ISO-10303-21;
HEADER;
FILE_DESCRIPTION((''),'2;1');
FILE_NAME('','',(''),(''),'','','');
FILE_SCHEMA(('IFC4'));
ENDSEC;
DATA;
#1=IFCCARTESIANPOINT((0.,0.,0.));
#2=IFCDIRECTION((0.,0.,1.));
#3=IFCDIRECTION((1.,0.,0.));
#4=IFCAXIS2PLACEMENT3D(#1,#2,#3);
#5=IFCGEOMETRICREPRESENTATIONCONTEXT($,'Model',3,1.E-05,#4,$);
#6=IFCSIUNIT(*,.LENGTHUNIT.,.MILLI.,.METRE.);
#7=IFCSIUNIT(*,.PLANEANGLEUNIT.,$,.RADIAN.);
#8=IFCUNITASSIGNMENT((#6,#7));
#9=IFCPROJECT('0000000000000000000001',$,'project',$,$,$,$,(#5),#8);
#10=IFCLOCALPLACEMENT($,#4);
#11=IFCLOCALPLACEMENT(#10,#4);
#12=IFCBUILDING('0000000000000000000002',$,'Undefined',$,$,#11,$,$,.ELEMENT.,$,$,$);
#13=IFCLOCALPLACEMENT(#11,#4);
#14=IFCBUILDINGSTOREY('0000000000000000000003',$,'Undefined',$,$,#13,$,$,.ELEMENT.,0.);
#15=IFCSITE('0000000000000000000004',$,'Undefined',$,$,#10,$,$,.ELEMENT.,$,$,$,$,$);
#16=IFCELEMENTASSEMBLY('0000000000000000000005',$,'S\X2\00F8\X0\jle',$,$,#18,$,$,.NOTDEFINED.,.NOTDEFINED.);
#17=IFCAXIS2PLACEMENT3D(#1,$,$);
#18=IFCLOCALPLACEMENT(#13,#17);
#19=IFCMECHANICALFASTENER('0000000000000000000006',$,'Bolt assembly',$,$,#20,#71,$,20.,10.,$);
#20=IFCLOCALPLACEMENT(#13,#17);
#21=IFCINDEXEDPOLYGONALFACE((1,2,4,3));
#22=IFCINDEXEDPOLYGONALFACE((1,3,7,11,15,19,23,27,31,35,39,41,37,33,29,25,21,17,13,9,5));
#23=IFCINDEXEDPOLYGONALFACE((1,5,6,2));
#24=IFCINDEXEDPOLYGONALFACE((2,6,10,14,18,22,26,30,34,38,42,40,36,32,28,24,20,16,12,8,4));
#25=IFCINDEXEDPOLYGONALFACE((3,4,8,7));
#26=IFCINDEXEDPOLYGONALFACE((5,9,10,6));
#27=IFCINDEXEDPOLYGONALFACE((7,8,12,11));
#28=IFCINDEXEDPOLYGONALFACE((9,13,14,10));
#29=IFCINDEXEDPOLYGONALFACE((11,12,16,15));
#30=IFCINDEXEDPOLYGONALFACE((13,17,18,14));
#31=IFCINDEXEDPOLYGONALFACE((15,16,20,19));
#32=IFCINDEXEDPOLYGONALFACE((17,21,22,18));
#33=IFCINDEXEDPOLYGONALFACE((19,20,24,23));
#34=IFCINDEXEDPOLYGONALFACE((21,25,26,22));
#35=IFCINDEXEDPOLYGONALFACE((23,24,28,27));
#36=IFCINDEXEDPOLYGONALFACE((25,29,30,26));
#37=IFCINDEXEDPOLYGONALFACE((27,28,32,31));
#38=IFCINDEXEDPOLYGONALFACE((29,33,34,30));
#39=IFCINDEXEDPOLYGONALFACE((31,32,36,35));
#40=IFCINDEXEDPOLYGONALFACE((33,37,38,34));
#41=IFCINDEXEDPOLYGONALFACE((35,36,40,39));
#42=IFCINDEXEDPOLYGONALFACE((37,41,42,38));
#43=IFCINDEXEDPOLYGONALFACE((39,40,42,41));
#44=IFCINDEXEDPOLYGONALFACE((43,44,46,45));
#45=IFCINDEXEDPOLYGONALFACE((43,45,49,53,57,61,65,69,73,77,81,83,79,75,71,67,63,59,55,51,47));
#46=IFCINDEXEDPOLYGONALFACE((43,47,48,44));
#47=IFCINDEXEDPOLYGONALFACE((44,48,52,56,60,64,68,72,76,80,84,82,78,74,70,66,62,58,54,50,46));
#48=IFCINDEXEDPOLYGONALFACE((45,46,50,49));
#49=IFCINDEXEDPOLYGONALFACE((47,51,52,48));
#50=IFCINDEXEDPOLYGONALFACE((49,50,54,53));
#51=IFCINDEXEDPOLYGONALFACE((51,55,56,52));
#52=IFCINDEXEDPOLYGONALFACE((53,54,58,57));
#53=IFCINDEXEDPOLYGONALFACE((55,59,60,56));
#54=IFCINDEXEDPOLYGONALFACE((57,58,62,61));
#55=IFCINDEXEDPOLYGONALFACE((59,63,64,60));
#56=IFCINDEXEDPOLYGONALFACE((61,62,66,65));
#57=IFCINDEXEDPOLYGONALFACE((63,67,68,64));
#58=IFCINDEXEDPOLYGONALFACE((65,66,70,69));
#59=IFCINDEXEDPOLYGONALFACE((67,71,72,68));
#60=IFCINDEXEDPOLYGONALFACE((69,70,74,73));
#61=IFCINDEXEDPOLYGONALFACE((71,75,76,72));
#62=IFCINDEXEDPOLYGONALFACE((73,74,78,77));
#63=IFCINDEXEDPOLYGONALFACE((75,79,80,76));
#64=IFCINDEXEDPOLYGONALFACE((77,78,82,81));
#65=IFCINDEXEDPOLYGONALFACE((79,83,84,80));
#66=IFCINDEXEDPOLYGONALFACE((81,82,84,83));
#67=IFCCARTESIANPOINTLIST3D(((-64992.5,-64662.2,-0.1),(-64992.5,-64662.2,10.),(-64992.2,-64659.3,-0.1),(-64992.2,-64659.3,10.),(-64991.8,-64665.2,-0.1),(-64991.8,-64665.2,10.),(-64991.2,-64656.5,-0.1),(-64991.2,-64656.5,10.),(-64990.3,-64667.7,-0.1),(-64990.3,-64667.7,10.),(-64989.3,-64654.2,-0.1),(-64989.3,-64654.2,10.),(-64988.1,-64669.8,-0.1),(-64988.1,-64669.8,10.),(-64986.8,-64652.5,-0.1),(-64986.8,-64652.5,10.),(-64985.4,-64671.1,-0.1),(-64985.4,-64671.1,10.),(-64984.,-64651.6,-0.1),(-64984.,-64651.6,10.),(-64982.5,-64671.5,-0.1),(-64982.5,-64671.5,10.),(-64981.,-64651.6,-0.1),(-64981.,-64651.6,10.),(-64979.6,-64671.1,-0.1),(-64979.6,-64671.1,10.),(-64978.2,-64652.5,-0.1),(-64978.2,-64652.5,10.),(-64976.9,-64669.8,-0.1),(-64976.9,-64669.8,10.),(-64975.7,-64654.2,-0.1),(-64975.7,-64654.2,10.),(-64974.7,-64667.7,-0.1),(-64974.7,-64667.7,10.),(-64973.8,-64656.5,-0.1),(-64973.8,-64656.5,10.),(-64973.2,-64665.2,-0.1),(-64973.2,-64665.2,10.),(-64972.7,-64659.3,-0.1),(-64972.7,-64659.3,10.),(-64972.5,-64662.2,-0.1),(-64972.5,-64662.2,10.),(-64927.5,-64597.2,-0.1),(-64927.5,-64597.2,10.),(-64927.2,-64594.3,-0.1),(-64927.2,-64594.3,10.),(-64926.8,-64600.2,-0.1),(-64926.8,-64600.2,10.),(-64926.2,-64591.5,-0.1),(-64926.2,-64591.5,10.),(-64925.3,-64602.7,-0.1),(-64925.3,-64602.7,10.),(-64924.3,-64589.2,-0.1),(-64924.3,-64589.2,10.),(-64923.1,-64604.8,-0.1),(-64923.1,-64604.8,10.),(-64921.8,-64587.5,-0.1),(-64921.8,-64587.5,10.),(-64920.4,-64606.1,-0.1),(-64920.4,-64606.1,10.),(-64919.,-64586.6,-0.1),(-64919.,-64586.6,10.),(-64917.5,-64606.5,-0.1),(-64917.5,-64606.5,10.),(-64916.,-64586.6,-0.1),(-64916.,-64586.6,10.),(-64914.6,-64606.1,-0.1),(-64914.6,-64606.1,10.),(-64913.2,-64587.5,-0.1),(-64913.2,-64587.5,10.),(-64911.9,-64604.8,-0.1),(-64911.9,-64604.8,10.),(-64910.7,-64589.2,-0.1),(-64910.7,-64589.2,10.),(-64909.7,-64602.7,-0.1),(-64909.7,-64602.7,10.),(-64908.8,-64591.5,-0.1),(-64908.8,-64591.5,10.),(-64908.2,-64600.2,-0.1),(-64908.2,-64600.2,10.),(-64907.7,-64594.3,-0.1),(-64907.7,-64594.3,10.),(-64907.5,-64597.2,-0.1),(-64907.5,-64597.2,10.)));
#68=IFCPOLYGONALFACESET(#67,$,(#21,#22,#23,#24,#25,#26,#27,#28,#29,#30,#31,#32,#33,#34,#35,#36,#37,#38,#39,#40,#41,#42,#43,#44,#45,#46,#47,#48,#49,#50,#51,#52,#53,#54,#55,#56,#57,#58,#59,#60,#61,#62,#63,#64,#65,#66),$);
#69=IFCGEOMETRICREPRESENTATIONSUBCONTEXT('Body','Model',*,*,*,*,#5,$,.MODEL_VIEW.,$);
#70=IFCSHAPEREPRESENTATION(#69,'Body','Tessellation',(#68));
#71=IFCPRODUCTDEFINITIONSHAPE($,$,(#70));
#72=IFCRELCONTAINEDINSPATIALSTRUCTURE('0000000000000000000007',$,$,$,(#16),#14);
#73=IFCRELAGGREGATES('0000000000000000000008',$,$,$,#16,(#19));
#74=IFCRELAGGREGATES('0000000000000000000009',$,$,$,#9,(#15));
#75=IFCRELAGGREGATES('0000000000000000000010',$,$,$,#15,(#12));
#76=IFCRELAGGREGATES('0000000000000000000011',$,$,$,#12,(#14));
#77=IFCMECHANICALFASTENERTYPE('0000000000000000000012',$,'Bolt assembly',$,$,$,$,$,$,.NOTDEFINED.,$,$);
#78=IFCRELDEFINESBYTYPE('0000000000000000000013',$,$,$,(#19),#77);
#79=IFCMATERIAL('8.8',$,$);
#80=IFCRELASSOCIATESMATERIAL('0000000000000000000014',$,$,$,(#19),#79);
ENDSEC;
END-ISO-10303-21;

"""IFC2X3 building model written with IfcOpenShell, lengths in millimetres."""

from ifc_helpers import new_model, si_unit, frame, origin_with_axes, origin_2d_with_axis, place, context, subcontext, project, spatial, circle, extrude, source, transform, mapped, material, type_object, element, aggregate, save


model = new_model("IFC2X3")

# Units and contexts
model_context = context("Model", 3, precision=1e-05, world=origin_with_axes())
body_context = subcontext(model_context, "Body", "Model", "MODEL_VIEW")
ifc_project = project(units=[si_unit("LENGTHUNIT", "METRE", prefix="MILLI"), si_unit("PLANEANGLEUNIT", "RADIAN")], contexts=[model_context])

# Site, building, storey
site_placement = place(None, origin_with_axes())
site = spatial("IfcSite", under=ifc_project, at=site_placement, Name="Undefined", CompositionType="ELEMENT")
building_placement = place(site_placement, origin_with_axes())
building = spatial("IfcBuilding", under=site, at=building_placement, Name="Undefined", CompositionType="ELEMENT")
storey_placement = place(building_placement, origin_with_axes())
storey = spatial("IfcBuildingStorey", under=building, at=storey_placement, Name="Undefined", CompositionType="ELEMENT", Elevation=0.0)

# Element assembly
assembly_1_placement = place(storey_placement, origin_with_axes())
assembly_1 = element("IfcElementAssembly", 1, at=assembly_1_placement, inside=storey, Name="Søjle", AssemblyPlace="NOTDEFINED", PredefinedType="NOTDEFINED")

# Mechanical fastener
ifc_material_1 = material(Name="8.8")
mechanical_fastener_type = type_object("IfcMechanicalFastenerType", Name="Bolt assembly")
shared_shape_1 = source(origin_with_axes(), body_context, "Body", "SweptSolid", [
    extrude(circle(Radius=10.0, at=origin_2d_with_axis()), frame((0.0, 0.0, 0.0), z_axis=(0.0, 1.0, 0.0), x_axis=(1.0, 0.0, 0.0)), (0.0, 0.0, 1.0), 10.1),
])
mechanical_fastener_1_placement = place(assembly_1_placement, frame((-64950.0, -64596.5, 10.0), z_axis=(1.0, 0.0, 0.0), x_axis=(0.0, -1.0, 0.0)))
mechanical_fastener_1 = element("IfcMechanicalFastener", 2, at=mechanical_fastener_1_placement, type_object=mechanical_fastener_type, material=ifc_material_1, Name="Bolt assembly", NominalDiameter=20.0, NominalLength=10.0, context=body_context, shape_type="MappedRepresentation", body=[
    mapped(shared_shape_1, transform((65.0, 0.0, -32.5))),
    mapped(shared_shape_1, transform((0.0, 0.0, 32.5))),
])
aggregate(assembly_1, [mechanical_fastener_1])

save(model, "model.ifc")
